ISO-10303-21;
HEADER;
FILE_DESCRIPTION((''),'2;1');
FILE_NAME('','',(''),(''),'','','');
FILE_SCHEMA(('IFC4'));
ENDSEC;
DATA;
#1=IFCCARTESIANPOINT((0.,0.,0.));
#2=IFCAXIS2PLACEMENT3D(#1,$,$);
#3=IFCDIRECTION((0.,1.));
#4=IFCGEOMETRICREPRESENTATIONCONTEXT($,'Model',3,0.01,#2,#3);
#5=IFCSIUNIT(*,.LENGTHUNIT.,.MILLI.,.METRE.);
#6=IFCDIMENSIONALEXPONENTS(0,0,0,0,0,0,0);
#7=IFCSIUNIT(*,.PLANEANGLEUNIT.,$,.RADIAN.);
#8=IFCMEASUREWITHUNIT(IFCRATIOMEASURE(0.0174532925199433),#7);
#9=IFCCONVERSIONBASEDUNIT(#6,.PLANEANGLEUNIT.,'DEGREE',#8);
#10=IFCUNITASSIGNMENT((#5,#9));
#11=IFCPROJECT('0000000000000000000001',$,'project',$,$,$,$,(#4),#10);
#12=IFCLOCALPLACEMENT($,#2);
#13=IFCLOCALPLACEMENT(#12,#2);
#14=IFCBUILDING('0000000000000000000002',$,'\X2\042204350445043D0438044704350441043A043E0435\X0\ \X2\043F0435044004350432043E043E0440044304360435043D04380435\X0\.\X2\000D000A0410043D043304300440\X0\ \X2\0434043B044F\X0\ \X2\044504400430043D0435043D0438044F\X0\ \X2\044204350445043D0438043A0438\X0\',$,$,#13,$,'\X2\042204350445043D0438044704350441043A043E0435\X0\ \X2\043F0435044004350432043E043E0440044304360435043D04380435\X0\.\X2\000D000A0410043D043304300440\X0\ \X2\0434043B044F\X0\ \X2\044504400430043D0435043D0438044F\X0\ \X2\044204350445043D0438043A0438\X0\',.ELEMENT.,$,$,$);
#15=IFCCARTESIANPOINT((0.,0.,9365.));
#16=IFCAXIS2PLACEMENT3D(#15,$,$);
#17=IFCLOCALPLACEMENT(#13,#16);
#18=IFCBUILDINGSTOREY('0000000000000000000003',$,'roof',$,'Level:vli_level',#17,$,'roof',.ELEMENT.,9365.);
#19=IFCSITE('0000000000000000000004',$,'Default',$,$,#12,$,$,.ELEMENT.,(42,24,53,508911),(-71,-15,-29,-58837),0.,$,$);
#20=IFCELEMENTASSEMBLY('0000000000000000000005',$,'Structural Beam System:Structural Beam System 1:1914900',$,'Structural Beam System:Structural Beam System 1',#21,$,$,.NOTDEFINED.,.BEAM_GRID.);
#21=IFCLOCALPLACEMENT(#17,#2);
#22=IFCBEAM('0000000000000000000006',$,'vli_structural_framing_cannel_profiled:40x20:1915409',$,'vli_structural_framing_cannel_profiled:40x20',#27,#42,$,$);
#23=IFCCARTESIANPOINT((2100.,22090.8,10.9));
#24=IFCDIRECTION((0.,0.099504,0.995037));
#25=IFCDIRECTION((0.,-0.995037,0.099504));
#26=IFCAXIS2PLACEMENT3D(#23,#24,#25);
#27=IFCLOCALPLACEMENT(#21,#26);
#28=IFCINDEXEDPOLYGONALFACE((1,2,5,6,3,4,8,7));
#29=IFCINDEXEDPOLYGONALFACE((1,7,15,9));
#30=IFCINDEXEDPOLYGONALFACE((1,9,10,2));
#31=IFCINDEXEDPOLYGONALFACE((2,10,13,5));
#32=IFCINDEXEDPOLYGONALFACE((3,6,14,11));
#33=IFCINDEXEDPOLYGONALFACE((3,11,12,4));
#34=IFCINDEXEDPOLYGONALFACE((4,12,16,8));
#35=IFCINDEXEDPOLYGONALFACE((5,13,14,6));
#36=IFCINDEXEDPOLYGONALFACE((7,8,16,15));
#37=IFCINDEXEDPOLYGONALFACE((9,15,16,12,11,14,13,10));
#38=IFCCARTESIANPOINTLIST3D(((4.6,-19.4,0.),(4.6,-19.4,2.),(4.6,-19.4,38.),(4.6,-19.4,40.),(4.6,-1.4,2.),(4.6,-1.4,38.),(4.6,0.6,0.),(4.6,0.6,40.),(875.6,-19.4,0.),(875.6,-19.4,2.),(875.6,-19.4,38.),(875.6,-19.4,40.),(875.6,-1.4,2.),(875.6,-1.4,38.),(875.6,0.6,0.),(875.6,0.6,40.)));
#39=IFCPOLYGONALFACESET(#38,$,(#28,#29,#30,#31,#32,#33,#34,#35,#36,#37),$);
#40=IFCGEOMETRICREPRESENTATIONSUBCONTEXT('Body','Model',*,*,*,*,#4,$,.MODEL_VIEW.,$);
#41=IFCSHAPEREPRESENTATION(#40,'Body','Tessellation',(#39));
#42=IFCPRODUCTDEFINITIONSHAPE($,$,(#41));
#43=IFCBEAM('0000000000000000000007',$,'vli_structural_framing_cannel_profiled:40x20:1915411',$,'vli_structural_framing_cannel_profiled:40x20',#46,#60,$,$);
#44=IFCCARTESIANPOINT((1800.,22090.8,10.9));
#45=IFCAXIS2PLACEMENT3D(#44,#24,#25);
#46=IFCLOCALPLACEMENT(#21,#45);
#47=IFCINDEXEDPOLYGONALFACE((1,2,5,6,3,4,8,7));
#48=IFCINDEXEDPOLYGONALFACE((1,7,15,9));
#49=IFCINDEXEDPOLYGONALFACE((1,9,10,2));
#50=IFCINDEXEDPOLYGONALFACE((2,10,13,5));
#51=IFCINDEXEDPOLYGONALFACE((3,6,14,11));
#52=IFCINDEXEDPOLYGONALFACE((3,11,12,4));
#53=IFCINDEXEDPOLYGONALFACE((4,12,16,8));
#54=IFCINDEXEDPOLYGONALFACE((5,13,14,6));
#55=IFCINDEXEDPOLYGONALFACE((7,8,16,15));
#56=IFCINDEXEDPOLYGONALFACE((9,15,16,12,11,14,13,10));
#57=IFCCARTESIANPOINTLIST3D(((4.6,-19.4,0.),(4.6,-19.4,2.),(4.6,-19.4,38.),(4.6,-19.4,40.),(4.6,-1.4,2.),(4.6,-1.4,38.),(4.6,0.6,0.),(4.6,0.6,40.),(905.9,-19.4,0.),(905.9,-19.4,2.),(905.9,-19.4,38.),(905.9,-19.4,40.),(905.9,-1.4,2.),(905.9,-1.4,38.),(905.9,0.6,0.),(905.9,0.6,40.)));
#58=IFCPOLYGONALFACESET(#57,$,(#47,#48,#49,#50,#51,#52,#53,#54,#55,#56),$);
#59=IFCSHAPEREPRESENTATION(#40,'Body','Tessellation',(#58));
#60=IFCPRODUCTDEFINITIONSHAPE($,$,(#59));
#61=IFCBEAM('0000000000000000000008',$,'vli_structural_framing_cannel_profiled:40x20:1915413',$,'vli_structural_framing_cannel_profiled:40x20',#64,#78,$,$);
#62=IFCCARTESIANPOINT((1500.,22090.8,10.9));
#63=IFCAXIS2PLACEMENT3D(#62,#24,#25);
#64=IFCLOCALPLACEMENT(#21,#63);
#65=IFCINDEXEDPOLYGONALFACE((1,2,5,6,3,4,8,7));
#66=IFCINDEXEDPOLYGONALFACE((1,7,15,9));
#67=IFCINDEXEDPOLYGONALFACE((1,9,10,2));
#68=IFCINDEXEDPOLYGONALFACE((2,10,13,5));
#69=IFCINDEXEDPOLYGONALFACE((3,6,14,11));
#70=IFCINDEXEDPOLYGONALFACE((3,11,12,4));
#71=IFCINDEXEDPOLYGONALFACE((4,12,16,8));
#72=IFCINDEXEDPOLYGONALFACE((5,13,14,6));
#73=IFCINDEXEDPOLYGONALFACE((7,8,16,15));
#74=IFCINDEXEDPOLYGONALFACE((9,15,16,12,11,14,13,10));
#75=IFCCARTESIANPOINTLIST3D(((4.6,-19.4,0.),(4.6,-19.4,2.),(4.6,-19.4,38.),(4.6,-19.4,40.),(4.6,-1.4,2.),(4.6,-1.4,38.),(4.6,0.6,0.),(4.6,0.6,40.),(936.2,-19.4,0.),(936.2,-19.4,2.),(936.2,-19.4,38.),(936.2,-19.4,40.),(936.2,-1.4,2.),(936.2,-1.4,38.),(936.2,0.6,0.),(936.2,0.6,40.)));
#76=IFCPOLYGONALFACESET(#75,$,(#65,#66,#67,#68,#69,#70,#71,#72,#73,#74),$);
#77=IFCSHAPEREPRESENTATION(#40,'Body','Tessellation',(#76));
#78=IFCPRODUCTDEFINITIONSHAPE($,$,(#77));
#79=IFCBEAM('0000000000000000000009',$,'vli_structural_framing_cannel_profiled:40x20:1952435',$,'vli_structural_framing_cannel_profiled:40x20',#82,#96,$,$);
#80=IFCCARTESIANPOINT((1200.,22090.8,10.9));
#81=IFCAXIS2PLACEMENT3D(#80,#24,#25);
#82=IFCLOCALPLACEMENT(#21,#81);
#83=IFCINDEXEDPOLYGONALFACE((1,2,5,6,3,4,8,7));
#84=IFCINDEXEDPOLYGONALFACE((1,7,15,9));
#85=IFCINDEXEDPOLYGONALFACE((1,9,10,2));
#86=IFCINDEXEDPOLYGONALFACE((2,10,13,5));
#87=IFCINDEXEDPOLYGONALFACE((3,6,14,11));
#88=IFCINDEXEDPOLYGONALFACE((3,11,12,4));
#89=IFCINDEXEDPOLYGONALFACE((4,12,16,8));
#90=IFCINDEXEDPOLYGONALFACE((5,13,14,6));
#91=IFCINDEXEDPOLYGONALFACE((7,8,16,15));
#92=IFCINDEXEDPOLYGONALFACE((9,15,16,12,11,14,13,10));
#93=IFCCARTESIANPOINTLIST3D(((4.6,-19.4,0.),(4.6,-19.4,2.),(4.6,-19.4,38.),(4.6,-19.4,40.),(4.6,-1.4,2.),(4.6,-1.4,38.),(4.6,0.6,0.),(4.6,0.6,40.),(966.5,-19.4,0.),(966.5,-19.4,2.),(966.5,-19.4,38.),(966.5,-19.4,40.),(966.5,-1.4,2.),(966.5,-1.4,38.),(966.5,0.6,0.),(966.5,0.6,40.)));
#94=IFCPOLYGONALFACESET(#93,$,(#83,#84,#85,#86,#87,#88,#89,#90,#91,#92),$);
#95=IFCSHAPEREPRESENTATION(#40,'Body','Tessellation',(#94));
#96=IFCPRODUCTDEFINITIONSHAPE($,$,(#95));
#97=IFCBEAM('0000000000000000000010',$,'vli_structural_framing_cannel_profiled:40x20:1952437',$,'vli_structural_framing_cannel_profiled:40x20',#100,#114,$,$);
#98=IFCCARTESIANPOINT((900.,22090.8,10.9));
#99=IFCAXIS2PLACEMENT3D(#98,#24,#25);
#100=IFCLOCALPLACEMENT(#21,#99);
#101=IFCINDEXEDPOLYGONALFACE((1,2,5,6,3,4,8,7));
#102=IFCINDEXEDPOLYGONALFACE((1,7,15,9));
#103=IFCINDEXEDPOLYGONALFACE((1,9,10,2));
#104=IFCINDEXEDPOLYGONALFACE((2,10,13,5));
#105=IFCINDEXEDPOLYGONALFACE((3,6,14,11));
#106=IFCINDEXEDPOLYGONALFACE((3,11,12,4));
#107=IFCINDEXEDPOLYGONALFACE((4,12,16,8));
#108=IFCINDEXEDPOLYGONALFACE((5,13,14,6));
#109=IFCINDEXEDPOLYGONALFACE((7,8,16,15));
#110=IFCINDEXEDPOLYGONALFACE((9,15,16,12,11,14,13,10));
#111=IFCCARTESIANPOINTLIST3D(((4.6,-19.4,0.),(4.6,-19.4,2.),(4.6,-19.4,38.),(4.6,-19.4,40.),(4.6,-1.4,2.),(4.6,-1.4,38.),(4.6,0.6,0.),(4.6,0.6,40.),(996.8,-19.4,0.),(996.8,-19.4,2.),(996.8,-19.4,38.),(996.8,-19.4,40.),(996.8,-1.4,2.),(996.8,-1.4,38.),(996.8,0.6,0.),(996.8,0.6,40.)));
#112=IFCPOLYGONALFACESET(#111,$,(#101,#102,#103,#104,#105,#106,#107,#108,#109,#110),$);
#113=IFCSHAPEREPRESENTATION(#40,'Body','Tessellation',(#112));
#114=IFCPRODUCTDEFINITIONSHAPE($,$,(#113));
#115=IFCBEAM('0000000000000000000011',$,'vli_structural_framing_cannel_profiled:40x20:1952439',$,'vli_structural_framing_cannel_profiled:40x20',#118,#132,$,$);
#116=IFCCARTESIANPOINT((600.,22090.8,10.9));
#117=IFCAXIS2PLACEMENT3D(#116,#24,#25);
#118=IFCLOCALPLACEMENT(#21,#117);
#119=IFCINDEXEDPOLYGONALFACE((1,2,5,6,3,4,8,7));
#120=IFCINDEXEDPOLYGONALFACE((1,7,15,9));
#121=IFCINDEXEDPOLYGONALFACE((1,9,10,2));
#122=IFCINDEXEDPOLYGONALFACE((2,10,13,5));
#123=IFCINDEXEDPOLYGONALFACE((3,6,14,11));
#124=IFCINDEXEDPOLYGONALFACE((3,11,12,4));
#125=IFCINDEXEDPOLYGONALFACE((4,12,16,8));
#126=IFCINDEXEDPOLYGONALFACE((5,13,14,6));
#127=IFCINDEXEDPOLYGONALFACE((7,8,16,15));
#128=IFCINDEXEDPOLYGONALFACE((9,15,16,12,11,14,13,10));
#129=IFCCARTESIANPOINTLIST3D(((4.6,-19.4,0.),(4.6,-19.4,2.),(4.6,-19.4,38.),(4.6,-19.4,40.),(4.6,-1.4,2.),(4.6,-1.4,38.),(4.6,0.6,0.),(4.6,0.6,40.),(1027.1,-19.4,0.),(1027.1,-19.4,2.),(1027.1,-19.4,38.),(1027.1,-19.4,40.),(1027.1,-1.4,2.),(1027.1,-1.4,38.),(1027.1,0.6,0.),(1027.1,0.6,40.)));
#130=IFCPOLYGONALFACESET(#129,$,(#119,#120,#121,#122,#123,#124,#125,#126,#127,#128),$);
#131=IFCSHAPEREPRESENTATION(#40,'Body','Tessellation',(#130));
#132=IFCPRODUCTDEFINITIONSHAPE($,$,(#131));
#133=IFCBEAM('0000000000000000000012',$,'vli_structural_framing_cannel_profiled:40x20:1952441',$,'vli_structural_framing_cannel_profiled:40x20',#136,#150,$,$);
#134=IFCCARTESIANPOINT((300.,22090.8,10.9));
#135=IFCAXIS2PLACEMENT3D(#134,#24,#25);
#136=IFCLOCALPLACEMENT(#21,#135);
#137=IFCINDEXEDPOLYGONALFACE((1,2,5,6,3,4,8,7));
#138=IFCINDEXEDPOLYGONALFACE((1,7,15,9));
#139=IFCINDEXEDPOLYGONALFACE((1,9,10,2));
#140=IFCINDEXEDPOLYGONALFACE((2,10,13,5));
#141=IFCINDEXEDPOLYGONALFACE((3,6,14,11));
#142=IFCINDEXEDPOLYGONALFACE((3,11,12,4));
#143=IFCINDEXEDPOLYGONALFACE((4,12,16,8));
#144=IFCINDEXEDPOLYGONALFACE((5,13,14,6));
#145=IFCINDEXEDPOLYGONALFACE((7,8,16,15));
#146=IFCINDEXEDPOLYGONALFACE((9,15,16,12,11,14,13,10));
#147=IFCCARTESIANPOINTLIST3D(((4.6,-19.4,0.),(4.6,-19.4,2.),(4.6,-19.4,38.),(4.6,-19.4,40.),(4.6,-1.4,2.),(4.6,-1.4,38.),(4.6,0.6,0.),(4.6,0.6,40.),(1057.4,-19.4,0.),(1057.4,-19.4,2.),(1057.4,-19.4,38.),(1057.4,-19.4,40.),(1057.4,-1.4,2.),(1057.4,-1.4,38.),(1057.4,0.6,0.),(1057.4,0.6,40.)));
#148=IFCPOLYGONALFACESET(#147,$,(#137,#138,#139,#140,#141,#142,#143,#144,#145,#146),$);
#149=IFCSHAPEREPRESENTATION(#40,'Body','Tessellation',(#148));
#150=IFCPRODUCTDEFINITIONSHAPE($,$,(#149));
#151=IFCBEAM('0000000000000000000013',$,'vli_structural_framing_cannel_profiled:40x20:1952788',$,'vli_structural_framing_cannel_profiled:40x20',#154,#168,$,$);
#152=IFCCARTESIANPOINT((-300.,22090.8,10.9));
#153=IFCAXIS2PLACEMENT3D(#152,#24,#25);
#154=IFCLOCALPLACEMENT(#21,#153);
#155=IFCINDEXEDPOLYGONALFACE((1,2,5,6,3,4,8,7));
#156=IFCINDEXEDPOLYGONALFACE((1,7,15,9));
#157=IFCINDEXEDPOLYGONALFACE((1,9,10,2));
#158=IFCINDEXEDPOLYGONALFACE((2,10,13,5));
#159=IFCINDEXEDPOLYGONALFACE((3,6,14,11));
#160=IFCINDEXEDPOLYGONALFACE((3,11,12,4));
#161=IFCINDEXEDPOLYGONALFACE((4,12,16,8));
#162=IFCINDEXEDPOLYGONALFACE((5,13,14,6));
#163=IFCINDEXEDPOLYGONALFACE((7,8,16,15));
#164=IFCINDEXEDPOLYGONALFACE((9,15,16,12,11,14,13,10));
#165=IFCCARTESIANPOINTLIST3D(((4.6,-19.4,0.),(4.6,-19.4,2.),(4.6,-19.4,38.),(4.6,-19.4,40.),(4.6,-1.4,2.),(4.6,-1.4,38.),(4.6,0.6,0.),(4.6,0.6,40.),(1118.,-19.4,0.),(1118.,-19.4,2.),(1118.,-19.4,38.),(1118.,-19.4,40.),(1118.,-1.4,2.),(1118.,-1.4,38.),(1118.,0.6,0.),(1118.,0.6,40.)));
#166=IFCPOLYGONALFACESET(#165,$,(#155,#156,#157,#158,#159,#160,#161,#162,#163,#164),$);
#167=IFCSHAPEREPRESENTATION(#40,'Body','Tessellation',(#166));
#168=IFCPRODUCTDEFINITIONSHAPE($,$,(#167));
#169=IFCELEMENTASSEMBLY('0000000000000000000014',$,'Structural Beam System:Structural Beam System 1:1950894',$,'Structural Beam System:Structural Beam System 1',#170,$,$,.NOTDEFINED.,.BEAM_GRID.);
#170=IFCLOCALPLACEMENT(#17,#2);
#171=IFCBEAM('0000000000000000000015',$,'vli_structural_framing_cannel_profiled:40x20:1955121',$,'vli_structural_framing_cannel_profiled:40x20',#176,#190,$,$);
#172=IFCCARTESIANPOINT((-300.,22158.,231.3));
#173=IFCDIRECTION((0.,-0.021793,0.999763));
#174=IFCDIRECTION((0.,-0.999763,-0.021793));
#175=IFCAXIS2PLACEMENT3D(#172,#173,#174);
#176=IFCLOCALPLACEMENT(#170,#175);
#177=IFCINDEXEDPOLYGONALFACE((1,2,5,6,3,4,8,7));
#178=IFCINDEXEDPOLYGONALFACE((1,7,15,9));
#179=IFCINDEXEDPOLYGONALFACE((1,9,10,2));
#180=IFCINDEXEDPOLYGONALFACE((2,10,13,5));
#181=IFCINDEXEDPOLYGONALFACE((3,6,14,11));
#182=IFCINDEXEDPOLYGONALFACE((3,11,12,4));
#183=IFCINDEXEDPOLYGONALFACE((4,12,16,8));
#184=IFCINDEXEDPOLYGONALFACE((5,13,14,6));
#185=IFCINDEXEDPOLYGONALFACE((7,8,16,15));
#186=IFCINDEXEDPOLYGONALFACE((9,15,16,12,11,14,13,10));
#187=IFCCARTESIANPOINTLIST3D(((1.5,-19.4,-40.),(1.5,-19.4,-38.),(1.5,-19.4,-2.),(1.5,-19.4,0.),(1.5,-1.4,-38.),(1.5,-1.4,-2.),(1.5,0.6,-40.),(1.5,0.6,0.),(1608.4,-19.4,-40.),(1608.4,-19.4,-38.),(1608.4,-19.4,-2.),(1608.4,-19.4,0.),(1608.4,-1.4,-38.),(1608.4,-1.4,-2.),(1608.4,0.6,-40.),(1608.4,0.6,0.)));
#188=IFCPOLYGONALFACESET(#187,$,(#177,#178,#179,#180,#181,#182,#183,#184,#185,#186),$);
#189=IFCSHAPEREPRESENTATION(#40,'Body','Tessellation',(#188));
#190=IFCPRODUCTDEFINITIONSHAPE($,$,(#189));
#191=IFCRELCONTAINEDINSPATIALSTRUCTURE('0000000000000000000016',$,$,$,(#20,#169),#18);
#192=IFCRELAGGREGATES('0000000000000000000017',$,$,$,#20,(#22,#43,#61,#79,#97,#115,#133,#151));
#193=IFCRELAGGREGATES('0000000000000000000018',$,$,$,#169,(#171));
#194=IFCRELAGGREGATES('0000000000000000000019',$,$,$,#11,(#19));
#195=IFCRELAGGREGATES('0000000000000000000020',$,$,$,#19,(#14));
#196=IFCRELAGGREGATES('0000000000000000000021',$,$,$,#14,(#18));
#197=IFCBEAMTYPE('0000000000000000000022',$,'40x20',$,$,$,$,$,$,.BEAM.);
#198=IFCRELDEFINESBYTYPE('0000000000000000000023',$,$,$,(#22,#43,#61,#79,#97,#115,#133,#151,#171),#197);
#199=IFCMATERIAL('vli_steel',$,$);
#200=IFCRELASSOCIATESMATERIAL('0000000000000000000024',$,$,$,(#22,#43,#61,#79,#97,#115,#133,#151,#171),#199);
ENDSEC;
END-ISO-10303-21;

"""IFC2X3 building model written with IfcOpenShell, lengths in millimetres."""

from ifc_helpers import new_model, entity, si_unit, converted_unit, direction, frame, origin, place, context, subcontext, project, spatial, polyline, outline, extrude, material, type_object, element, aggregate, save


model = new_model("IFC2X3")

# Units and contexts
model_context = context("Model", 3, precision=0.01, world=origin(), true_north=direction((0.0, 1.0)))
body_context = subcontext(model_context, "Body", "Model", "MODEL_VIEW")
ifc_project = project(units=[si_unit("LENGTHUNIT", "METRE", prefix="MILLI"), converted_unit("PLANEANGLEUNIT", "DEGREE", entity("IfcRatioMeasure", 0.0174532925199433), si_unit("PLANEANGLEUNIT", "RADIAN"), dimensions=[0, 0, 0, 0, 0, 0, 0])], contexts=[model_context])

# Site, building, storey
site_placement = place(None, origin())
site = spatial("IfcSite", under=ifc_project, at=site_placement, Name="Default", CompositionType="ELEMENT", RefLatitude=(42, 24, 53, 508911), RefLongitude=(-71, -15, -29, -58837), RefElevation=0.0)
building_placement = place(site_placement, origin())
building = spatial("IfcBuilding", under=site, at=building_placement, Name="Техническое перевооружение.\r\nАнгар для хранения техники", LongName="Техническое перевооружение.\r\nАнгар для хранения техники", CompositionType="ELEMENT")
storey_placement = place(building_placement, frame((0.0, 0.0, 9365.0)))
storey = spatial("IfcBuildingStorey", under=building, at=storey_placement, Name="roof", ObjectType="Level:vli_level", LongName="roof", CompositionType="ELEMENT", Elevation=9365.0)

# Element assemblies, beams
assembly_1_placement = place(storey_placement, origin())
assembly_1 = element("IfcElementAssembly", 1, at=assembly_1_placement, inside=storey, Name="Structural Beam System:Structural Beam System 1:1914900", ObjectType="Structural Beam System:Structural Beam System 1", AssemblyPlace="NOTDEFINED", PredefinedType="BEAM_GRID")
ifc_material = material(Name="vli_steel")
beam_type = type_object("IfcBeamType", Name="40x20", PredefinedType="BEAM")
beam_1_placement = place(assembly_1_placement, frame((2100.0, 22090.8, 10.9), z_axis=(0.0, 0.099504, 0.995037), x_axis=(0.0, -0.995037, 0.099504)))
beam_1 = element("IfcBeam", 2, at=beam_1_placement, type_object=beam_type, material=ifc_material, Name="vli_structural_framing_cannel_profiled:40x20:1915409", ObjectType="vli_structural_framing_cannel_profiled:40x20", context=body_context, shape_type="SweptSolid", body=[
    extrude(outline(polyline([(-20.0, -9.5), (-18.0, -9.5), (-18.0, 8.5), (18.0, 8.5), (18.0, -9.5), (20.0, -9.5), (20.0, 10.5), (-20.0, 10.5), (-20.0, -9.5)])), frame((4.6, -9.9, 20.0), z_axis=(1.0, 0.0, 0.0), x_axis=(0.0, 0.0, -1.0)), (0.0, 0.0, 1.0), 871.1),
])
beam_2_placement = place(assembly_1_placement, frame((1800.0, 22090.8, 10.9), z_axis=(0.0, 0.099504, 0.995037), x_axis=(0.0, -0.995037, 0.099504)))
beam_2 = element("IfcBeam", 3, at=beam_2_placement, type_object=beam_type, material=ifc_material, Name="vli_structural_framing_cannel_profiled:40x20:1915411", ObjectType="vli_structural_framing_cannel_profiled:40x20", context=body_context, shape_type="SweptSolid", body=[
    extrude(outline(polyline([(-20.0, -9.5), (-18.0, -9.5), (-18.0, 8.5), (18.0, 8.5), (18.0, -9.5), (20.0, -9.5), (20.0, 10.5), (-20.0, 10.5), (-20.0, -9.5)])), frame((4.6, -9.9, 20.0), z_axis=(1.0, 0.0, 0.0), x_axis=(0.0, 0.0, -1.0)), (0.0, 0.0, 1.0), 901.4),
])
beam_3_placement = place(assembly_1_placement, frame((1500.0, 22090.8, 10.9), z_axis=(0.0, 0.099504, 0.995037), x_axis=(0.0, -0.995037, 0.099504)))
beam_3 = element("IfcBeam", 4, at=beam_3_placement, type_object=beam_type, material=ifc_material, Name="vli_structural_framing_cannel_profiled:40x20:1915413", ObjectType="vli_structural_framing_cannel_profiled:40x20", context=body_context, shape_type="SweptSolid", body=[
    extrude(outline(polyline([(-20.0, -9.5), (-18.0, -9.5), (-18.0, 8.5), (18.0, 8.5), (18.0, -9.5), (20.0, -9.5), (20.0, 10.5), (-20.0, 10.5), (-20.0, -9.5)])), frame((4.6, -9.9, 20.0), z_axis=(1.0, 0.0, 0.0), x_axis=(0.0, 0.0, -1.0)), (0.0, 0.0, 1.0), 931.7),
])
beam_4_placement = place(assembly_1_placement, frame((1200.0, 22090.8, 10.9), z_axis=(0.0, 0.099504, 0.995037), x_axis=(0.0, -0.995037, 0.099504)))
beam_4 = element("IfcBeam", 5, at=beam_4_placement, type_object=beam_type, material=ifc_material, Name="vli_structural_framing_cannel_profiled:40x20:1952435", ObjectType="vli_structural_framing_cannel_profiled:40x20", context=body_context, shape_type="SweptSolid", body=[
    extrude(outline(polyline([(-20.0, -9.5), (-18.0, -9.5), (-18.0, 8.5), (18.0, 8.5), (18.0, -9.5), (20.0, -9.5), (20.0, 10.5), (-20.0, 10.5), (-20.0, -9.5)])), frame((4.6, -9.9, 20.0), z_axis=(1.0, 0.0, 0.0), x_axis=(0.0, 0.0, -1.0)), (0.0, 0.0, 1.0), 962.0),
])
beam_5_placement = place(assembly_1_placement, frame((900.0, 22090.8, 10.9), z_axis=(0.0, 0.099504, 0.995037), x_axis=(0.0, -0.995037, 0.099504)))
beam_5 = element("IfcBeam", 6, at=beam_5_placement, type_object=beam_type, material=ifc_material, Name="vli_structural_framing_cannel_profiled:40x20:1952437", ObjectType="vli_structural_framing_cannel_profiled:40x20", context=body_context, shape_type="SweptSolid", body=[
    extrude(outline(polyline([(-20.0, -9.5), (-18.0, -9.5), (-18.0, 8.5), (18.0, 8.5), (18.0, -9.5), (20.0, -9.5), (20.0, 10.5), (-20.0, 10.5), (-20.0, -9.5)])), frame((4.6, -9.9, 20.0), z_axis=(1.0, 0.0, 0.0), x_axis=(0.0, 0.0, -1.0)), (0.0, 0.0, 1.0), 992.3),
])
beam_6_placement = place(assembly_1_placement, frame((600.0, 22090.8, 10.9), z_axis=(0.0, 0.099504, 0.995037), x_axis=(0.0, -0.995037, 0.099504)))
beam_6 = element("IfcBeam", 7, at=beam_6_placement, type_object=beam_type, material=ifc_material, Name="vli_structural_framing_cannel_profiled:40x20:1952439", ObjectType="vli_structural_framing_cannel_profiled:40x20", context=body_context, shape_type="SweptSolid", body=[
    extrude(outline(polyline([(-20.0, -9.5), (-18.0, -9.5), (-18.0, 8.5), (18.0, 8.5), (18.0, -9.5), (20.0, -9.5), (20.0, 10.5), (-20.0, 10.5), (-20.0, -9.5)])), frame((4.6, -9.9, 20.0), z_axis=(1.0, 0.0, 0.0), x_axis=(0.0, 0.0, -1.0)), (0.0, 0.0, 1.0), 1022.6),
])
beam_7_placement = place(assembly_1_placement, frame((300.0, 22090.8, 10.9), z_axis=(0.0, 0.099504, 0.995037), x_axis=(0.0, -0.995037, 0.099504)))
beam_7 = element("IfcBeam", 8, at=beam_7_placement, type_object=beam_type, material=ifc_material, Name="vli_structural_framing_cannel_profiled:40x20:1952441", ObjectType="vli_structural_framing_cannel_profiled:40x20", context=body_context, shape_type="SweptSolid", body=[
    extrude(outline(polyline([(-20.0, -9.5), (-18.0, -9.5), (-18.0, 8.5), (18.0, 8.5), (18.0, -9.5), (20.0, -9.5), (20.0, 10.5), (-20.0, 10.5), (-20.0, -9.5)])), frame((4.6, -9.9, 20.0), z_axis=(1.0, 0.0, 0.0), x_axis=(0.0, 0.0, -1.0)), (0.0, 0.0, 1.0), 1052.9),
])
beam_8_placement = place(assembly_1_placement, frame((-300.0, 22090.8, 10.9), z_axis=(0.0, 0.099504, 0.995037), x_axis=(0.0, -0.995037, 0.099504)))
beam_8 = element("IfcBeam", 9, at=beam_8_placement, type_object=beam_type, material=ifc_material, Name="vli_structural_framing_cannel_profiled:40x20:1952788", ObjectType="vli_structural_framing_cannel_profiled:40x20", context=body_context, shape_type="SweptSolid", body=[
    extrude(outline(polyline([(-20.0, -9.5), (-18.0, -9.5), (-18.0, 8.5), (18.0, 8.5), (18.0, -9.5), (20.0, -9.5), (20.0, 10.5), (-20.0, 10.5), (-20.0, -9.5)])), frame((4.6, -9.9, 20.0), z_axis=(1.0, 0.0, 0.0), x_axis=(0.0, 0.0, -1.0)), (0.0, 0.0, 1.0), 1113.5),
])
aggregate(assembly_1, [beam_1, beam_2, beam_3, beam_4, beam_5, beam_6, beam_7, beam_8])
assembly_2_placement = place(storey_placement, origin())
assembly_2 = element("IfcElementAssembly", 10, at=assembly_2_placement, inside=storey, Name="Structural Beam System:Structural Beam System 1:1950894", ObjectType="Structural Beam System:Structural Beam System 1", AssemblyPlace="NOTDEFINED", PredefinedType="BEAM_GRID")
beam_9_placement = place(assembly_2_placement, frame((-300.0, 22158.0, 231.3), z_axis=(0.0, -0.021793, 0.999763), x_axis=(0.0, -0.999763, -0.021793)))
beam_9 = element("IfcBeam", 11, at=beam_9_placement, type_object=beam_type, material=ifc_material, Name="vli_structural_framing_cannel_profiled:40x20:1955121", ObjectType="vli_structural_framing_cannel_profiled:40x20", context=body_context, shape_type="SweptSolid", body=[
    extrude(outline(polyline([(-20.0, -9.5), (-18.0, -9.5), (-18.0, 8.5), (18.0, 8.5), (18.0, -9.5), (20.0, -9.5), (20.0, 10.5), (-20.0, 10.5), (-20.0, -9.5)])), frame((1.5, -9.9, -20.0), z_axis=(1.0, 0.0, 0.0), x_axis=(0.0, 0.0, -1.0)), (0.0, 0.0, 1.0), 1606.9),
])
aggregate(assembly_2, [beam_9])

save(model, "model.ifc")
